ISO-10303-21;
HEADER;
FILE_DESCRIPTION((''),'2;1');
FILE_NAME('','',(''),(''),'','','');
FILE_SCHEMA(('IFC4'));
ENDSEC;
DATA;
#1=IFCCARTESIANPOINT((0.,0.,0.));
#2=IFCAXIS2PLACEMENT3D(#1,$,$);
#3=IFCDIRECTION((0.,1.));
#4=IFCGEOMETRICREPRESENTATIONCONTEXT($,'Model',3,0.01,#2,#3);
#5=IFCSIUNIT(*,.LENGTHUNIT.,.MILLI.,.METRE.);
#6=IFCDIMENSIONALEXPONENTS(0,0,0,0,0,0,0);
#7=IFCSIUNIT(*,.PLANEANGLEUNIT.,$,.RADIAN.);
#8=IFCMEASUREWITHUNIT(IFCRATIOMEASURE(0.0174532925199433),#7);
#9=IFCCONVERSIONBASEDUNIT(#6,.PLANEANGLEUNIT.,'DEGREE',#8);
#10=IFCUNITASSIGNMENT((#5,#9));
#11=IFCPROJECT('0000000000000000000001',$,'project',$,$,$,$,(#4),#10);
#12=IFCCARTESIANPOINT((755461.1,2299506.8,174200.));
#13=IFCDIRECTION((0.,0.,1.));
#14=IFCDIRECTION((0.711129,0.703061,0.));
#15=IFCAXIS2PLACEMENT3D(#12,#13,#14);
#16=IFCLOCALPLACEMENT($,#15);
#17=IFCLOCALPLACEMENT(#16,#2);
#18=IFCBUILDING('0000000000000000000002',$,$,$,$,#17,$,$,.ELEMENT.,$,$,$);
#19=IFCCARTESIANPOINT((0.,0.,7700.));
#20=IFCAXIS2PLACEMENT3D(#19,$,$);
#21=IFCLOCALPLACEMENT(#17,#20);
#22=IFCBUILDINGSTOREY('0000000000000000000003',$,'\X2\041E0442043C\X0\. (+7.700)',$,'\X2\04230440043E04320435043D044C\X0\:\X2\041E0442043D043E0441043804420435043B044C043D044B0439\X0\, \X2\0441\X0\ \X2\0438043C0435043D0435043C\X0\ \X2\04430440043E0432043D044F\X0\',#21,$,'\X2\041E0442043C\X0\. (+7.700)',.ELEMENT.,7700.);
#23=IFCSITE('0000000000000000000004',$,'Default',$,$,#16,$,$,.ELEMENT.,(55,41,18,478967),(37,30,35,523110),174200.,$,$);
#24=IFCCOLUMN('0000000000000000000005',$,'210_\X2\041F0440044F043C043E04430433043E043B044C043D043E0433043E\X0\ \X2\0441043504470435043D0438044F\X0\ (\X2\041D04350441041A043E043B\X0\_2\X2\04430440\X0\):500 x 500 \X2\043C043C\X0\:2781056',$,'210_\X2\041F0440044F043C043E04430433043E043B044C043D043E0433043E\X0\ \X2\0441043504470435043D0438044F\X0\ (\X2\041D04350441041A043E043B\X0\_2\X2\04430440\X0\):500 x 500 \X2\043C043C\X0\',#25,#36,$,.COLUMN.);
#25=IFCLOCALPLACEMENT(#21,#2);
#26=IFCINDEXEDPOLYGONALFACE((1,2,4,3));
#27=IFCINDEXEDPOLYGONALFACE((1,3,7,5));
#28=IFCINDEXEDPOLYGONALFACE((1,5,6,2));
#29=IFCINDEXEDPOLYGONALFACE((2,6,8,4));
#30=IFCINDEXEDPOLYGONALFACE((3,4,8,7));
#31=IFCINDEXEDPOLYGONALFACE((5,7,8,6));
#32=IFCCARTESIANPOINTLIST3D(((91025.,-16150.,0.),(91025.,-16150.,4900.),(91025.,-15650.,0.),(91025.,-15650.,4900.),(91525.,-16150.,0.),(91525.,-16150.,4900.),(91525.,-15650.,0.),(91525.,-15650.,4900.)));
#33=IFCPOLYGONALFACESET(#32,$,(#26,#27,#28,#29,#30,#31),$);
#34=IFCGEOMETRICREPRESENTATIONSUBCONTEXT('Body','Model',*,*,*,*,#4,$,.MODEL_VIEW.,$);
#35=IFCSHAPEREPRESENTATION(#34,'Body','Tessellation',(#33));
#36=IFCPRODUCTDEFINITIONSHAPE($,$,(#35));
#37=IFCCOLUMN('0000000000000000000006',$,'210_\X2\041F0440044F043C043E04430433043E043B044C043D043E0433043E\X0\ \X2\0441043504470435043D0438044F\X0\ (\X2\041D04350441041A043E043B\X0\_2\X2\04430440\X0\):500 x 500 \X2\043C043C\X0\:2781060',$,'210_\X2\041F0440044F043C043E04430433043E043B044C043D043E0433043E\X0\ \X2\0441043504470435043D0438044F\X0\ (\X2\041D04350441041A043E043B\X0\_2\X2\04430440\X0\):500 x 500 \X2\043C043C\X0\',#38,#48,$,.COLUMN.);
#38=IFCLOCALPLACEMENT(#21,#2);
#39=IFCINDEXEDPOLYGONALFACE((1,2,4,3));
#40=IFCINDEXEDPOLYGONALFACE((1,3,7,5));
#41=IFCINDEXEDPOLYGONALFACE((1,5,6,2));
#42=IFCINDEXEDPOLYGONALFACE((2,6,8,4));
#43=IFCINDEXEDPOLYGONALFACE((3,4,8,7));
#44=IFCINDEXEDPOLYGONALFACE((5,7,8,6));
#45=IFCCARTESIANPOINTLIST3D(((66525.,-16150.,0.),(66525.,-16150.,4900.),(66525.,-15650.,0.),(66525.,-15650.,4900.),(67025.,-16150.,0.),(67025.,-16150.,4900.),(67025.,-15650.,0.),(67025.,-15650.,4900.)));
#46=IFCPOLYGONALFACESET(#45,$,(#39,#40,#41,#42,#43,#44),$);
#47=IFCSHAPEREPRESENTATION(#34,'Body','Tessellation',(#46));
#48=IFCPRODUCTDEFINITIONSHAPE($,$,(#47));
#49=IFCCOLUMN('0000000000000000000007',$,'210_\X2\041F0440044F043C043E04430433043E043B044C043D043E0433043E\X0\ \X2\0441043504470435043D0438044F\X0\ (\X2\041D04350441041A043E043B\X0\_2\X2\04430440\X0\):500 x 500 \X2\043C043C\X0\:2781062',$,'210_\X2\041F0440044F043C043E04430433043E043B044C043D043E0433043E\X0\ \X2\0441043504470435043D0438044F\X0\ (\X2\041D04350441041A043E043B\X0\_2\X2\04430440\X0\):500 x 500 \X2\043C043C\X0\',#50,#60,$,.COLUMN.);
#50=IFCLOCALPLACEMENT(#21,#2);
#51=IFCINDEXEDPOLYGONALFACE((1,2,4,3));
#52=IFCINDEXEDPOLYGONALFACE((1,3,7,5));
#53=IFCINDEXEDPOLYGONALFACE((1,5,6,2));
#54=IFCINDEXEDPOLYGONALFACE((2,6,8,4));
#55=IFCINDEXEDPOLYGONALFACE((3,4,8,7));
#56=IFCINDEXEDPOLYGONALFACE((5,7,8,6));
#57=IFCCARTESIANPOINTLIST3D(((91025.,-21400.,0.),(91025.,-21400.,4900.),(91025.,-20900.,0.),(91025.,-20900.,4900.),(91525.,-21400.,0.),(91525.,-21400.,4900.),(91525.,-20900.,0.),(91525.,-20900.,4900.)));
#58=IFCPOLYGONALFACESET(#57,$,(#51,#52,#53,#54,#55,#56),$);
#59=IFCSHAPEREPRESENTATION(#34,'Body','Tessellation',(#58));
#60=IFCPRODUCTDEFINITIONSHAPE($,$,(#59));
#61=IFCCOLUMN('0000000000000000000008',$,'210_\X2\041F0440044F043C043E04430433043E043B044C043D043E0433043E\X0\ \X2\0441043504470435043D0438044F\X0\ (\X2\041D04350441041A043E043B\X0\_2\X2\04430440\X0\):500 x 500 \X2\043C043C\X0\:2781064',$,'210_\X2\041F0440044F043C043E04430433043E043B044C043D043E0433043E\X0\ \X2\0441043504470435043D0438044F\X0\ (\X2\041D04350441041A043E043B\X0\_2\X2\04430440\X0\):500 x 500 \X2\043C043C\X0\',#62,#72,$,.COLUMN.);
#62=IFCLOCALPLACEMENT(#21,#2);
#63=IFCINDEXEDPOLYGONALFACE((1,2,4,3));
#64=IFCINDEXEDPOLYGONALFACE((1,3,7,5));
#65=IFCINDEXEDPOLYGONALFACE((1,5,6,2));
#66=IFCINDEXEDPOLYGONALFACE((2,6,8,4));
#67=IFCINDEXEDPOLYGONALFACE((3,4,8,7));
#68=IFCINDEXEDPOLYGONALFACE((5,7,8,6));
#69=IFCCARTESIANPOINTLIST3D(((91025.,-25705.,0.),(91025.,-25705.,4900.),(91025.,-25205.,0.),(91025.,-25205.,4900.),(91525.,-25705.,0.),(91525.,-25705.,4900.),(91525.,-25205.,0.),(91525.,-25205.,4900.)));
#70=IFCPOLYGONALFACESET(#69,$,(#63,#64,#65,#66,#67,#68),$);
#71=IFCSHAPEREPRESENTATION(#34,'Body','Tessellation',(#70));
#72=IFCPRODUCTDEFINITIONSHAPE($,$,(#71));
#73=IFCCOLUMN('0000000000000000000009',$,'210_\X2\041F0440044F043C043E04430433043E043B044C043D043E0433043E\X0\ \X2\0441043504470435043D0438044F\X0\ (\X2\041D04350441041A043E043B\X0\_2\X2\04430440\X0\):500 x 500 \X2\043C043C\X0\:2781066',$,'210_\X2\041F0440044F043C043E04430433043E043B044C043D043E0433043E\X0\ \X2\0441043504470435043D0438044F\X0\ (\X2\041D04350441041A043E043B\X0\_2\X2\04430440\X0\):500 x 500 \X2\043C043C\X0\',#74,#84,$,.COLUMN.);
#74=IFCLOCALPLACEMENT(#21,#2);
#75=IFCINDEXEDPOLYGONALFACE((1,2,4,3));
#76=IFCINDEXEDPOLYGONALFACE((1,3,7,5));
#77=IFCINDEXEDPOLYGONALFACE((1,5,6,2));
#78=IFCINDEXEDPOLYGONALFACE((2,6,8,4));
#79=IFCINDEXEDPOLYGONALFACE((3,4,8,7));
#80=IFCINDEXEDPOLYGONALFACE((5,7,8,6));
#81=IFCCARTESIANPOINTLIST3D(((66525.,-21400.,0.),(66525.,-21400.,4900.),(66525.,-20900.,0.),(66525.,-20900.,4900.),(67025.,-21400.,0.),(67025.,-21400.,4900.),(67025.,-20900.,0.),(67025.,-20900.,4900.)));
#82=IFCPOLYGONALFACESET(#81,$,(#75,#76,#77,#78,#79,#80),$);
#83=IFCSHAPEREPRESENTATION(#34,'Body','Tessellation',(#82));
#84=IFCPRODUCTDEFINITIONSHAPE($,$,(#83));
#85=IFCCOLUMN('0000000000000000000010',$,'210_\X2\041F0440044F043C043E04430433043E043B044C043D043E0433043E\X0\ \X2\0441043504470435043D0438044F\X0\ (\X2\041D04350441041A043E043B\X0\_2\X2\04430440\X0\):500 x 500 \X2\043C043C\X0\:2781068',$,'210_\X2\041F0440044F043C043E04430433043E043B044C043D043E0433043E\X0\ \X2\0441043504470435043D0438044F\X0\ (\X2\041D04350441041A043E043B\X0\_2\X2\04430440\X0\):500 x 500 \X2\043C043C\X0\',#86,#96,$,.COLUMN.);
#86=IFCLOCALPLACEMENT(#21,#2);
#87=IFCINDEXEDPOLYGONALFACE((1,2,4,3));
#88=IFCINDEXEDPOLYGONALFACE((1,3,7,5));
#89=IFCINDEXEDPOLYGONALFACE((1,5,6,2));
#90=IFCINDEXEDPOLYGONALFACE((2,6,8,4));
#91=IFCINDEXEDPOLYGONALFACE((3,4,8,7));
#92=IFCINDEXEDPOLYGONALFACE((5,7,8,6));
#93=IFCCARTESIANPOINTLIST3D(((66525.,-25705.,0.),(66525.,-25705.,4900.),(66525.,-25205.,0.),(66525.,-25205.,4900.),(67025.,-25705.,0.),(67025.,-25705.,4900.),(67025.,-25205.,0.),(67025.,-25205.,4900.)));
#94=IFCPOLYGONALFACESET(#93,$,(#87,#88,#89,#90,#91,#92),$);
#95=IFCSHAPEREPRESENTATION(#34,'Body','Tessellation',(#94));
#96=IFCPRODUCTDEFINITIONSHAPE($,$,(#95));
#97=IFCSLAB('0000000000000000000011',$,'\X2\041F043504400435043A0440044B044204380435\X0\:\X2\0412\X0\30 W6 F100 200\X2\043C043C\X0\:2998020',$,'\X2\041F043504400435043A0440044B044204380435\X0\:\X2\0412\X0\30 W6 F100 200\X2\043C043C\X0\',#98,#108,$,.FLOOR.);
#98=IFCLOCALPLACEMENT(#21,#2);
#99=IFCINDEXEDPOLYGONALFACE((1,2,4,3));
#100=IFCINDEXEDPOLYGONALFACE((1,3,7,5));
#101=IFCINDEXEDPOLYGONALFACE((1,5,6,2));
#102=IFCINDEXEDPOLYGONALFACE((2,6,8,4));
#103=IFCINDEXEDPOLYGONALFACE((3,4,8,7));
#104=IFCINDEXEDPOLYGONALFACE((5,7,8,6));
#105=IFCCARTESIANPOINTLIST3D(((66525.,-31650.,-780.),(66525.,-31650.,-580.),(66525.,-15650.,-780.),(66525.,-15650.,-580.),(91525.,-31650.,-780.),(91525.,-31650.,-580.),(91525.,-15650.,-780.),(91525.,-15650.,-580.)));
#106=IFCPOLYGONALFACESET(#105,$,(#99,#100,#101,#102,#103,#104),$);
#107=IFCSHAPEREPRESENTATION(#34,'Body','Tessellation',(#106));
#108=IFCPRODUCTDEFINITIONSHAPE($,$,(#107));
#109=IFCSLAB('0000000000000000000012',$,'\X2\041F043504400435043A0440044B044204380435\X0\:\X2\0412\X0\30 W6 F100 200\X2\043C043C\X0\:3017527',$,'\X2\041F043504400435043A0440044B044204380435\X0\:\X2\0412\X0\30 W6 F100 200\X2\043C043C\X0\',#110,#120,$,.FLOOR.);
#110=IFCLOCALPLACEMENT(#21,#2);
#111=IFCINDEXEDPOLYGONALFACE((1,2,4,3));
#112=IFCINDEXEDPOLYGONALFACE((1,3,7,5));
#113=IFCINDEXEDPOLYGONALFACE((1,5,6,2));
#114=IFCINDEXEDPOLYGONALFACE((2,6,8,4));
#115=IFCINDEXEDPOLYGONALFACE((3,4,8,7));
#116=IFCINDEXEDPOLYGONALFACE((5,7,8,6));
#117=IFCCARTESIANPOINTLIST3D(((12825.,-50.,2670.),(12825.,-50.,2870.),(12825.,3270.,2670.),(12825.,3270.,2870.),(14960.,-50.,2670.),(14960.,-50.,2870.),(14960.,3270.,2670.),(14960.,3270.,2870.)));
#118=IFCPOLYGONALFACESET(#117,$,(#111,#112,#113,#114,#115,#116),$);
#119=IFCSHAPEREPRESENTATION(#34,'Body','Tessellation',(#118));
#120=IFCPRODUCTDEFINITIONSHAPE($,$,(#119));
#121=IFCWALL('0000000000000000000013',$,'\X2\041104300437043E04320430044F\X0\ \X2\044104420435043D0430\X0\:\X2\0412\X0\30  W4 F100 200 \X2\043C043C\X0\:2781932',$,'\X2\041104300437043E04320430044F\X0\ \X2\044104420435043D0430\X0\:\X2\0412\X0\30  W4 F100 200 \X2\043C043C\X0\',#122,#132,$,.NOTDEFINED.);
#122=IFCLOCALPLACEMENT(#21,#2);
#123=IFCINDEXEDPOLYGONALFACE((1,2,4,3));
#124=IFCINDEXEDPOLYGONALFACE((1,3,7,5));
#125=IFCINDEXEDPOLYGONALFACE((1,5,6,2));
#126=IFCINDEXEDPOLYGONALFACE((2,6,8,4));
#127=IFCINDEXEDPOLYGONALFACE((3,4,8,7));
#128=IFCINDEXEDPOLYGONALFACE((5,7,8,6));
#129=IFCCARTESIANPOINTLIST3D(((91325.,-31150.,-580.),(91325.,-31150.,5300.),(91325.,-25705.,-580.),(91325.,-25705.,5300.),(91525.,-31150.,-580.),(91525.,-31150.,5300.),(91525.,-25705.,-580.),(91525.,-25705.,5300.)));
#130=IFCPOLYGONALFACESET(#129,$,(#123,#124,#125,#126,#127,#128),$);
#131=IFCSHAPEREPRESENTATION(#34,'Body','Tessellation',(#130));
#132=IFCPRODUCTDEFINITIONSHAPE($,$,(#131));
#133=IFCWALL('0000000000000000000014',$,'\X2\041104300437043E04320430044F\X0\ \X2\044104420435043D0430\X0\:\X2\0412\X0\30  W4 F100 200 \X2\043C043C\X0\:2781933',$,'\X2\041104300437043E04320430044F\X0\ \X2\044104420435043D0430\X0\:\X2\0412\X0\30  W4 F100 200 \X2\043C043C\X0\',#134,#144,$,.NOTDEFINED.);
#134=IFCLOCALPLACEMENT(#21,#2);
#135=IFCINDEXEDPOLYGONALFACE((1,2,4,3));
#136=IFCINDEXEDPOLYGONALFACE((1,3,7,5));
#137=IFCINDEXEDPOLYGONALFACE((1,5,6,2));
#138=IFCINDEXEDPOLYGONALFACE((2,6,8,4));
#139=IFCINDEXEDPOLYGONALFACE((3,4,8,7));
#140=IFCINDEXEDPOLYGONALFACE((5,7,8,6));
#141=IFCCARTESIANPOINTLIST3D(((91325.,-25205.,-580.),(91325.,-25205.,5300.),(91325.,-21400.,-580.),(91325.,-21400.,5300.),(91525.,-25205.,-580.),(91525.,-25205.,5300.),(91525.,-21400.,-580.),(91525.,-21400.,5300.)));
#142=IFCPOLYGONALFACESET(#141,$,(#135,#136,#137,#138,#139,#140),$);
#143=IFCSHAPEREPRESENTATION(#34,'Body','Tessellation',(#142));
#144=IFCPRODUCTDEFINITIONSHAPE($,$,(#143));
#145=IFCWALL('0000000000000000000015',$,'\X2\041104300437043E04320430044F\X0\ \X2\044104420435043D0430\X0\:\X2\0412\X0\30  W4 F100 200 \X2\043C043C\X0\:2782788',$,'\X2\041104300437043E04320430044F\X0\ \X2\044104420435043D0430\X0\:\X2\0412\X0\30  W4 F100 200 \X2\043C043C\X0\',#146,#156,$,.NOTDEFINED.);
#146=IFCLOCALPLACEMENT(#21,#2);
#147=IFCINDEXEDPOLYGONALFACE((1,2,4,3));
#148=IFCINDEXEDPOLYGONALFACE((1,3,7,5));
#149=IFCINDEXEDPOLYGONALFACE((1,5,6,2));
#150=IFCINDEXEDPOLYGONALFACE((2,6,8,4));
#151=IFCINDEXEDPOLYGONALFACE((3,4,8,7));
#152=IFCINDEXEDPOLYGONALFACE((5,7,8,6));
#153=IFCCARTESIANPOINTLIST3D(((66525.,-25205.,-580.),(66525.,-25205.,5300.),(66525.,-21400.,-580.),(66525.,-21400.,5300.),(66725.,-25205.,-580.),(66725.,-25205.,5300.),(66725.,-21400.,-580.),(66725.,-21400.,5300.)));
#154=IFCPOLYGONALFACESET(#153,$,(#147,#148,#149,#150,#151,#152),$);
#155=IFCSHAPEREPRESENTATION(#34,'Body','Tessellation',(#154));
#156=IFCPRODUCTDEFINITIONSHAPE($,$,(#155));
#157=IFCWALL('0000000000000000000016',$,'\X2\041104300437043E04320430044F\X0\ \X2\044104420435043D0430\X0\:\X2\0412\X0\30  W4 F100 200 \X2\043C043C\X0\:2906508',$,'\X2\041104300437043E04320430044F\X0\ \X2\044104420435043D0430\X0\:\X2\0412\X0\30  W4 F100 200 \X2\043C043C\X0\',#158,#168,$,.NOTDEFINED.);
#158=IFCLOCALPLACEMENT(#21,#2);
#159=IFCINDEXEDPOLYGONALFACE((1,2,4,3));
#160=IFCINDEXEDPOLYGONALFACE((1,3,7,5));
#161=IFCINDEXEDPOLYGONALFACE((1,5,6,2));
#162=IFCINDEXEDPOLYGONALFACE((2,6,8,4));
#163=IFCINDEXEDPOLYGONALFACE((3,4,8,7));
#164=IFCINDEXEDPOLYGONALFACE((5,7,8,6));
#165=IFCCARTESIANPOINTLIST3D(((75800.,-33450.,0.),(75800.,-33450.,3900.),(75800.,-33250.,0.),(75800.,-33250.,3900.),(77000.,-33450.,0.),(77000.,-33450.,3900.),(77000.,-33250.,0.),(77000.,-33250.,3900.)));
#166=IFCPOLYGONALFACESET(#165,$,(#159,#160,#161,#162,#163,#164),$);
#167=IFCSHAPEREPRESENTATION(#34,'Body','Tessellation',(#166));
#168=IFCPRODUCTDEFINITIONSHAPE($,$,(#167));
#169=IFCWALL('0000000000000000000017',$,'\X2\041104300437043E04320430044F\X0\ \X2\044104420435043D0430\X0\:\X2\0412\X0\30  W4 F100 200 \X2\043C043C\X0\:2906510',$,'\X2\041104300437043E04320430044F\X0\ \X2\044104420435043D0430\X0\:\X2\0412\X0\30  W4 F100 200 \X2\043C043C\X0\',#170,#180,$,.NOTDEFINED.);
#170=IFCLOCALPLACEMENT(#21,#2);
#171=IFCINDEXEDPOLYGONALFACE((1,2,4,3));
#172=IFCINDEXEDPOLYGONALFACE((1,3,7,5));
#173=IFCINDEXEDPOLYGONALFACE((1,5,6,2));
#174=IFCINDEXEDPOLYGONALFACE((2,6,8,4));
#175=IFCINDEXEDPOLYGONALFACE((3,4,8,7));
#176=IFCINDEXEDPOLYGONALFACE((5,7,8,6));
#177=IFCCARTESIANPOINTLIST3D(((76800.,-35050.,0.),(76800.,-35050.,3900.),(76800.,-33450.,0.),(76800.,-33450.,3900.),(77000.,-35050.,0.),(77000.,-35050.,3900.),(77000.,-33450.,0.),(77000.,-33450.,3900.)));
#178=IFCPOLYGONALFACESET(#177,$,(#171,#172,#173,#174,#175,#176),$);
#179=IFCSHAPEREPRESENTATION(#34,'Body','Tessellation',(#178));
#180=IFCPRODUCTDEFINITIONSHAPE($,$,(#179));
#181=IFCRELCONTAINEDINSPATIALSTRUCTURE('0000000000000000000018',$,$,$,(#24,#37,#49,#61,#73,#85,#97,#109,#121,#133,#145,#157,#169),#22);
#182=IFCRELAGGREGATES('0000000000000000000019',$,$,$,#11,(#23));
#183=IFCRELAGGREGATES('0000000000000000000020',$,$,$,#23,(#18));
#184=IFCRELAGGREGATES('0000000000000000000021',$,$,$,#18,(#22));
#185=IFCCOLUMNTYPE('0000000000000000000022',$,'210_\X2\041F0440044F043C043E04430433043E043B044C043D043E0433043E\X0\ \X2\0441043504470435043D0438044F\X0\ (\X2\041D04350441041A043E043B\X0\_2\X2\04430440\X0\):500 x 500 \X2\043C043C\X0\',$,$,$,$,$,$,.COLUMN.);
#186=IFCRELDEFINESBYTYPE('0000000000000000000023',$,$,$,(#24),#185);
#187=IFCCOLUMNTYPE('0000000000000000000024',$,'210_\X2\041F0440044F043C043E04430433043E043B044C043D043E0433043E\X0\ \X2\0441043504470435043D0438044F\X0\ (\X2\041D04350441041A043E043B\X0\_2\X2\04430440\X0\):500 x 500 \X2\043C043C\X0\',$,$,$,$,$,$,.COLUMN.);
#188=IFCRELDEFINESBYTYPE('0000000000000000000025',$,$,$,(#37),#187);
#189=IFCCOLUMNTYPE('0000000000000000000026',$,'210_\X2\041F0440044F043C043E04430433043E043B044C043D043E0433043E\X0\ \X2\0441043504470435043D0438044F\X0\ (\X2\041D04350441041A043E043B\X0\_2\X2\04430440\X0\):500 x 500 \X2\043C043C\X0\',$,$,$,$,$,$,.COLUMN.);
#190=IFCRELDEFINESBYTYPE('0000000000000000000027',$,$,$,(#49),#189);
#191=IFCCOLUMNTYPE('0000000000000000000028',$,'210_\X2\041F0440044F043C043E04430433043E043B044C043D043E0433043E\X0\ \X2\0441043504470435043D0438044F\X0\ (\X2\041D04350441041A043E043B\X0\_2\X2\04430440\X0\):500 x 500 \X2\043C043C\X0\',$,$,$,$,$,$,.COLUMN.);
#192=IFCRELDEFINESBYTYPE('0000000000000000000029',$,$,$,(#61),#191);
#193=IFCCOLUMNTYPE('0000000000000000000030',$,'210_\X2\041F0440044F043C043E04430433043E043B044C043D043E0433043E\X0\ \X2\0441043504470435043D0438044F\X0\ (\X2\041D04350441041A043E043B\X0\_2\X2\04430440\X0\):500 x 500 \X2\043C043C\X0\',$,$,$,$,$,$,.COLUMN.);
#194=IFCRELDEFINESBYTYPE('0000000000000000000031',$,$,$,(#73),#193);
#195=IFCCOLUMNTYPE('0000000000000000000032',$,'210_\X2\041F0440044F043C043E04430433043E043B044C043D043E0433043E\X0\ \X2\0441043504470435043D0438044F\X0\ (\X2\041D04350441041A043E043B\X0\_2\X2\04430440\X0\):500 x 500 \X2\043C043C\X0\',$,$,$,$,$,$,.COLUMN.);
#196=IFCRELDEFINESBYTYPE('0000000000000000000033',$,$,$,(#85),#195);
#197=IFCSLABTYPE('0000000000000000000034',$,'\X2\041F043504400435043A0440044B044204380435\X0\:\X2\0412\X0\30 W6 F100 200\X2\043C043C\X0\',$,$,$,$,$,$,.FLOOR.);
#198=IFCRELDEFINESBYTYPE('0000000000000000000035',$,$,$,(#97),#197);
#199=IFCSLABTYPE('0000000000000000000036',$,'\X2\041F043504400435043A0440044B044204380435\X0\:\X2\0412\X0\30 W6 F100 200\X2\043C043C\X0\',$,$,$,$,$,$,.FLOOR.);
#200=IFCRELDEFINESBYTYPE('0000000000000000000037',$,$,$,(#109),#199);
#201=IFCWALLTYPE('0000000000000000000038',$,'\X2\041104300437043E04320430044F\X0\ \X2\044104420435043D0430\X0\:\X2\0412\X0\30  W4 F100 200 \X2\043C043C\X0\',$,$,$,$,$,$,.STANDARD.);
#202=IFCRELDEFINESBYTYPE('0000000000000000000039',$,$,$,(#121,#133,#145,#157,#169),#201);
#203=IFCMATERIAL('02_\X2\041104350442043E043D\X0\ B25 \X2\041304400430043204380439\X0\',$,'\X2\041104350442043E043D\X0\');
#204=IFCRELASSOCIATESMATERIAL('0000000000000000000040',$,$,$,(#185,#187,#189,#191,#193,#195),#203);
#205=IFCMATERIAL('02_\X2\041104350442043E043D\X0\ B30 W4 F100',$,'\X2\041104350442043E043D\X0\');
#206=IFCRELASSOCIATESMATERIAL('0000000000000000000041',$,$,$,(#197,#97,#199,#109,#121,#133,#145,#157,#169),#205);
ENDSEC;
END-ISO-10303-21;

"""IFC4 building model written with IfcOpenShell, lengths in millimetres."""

from ifc_helpers import new_model, entity, si_unit, converted_unit, direction, frame, origin, place, context, subcontext, project, spatial, indexed_curve, outline, extrude, source, transform, mapped, material, type_object, type_shapes, element, save


model = new_model("IFC4")

# Units and contexts
model_context = context("Model", 3, precision=0.01, world=origin(), true_north=direction((0.0, 1.0)))
body_context = subcontext(model_context, "Body", "Model", "MODEL_VIEW")
ifc_project = project(units=[si_unit("LENGTHUNIT", "METRE", prefix="MILLI"), converted_unit("PLANEANGLEUNIT", "DEGREE", entity("IfcRatioMeasure", 0.0174532925199433), si_unit("PLANEANGLEUNIT", "RADIAN"), dimensions=[0, 0, 0, 0, 0, 0, 0])], contexts=[model_context])

# Site, building, storey
site_placement = place(None, frame((755461.1, 2299506.8, 174200.0), z_axis=(0.0, 0.0, 1.0), x_axis=(0.711129, 0.703061, 0.0)))
site = spatial("IfcSite", under=ifc_project, at=site_placement, Name="Default", CompositionType="ELEMENT", RefLatitude=(55, 41, 18, 478967), RefLongitude=(37, 30, 35, 523110), RefElevation=174200.0)
building_placement = place(site_placement, origin())
building = spatial("IfcBuilding", under=site, at=building_placement, CompositionType="ELEMENT")
storey_placement = place(building_placement, frame((0.0, 0.0, 7700.0)))
storey = spatial("IfcBuildingStorey", under=building, at=storey_placement, Name="Отм. (+7.700)", ObjectType="Уровень:Относительный, с именем уровня", LongName="Отм. (+7.700)", CompositionType="ELEMENT", Elevation=7700.0)

# Columns
ifc_material_1 = material(Name="02_Бетон B25 Гравий", Category="Бетон")
column_type_1 = type_object("IfcColumnType", Name="210_Прямоугольного сечения (НесКол_2ур):500 x 500 мм", PredefinedType="COLUMN", material=ifc_material_1)
shared_shape_1 = source(origin(), body_context, "Body", "SweptSolid", [
    extrude(outline(indexed_curve([(-250.0, -250.0), (250.0, -250.0), (250.0, 250.0), (-250.0, 250.0), (-250.0, -250.0)], self_intersect=False)), frame((91275.0, -15900.0, 7700.0), z_axis=(0.0, 0.0, 1.0), x_axis=(0.0, -1.0, 0.0)), (0.0, 0.0, 1.0), 4900.0),
])
type_shapes(column_type_1, [shared_shape_1])
column_1_placement = place(storey_placement, frame((0.0, 0.0, -7700.0)))
element("IfcColumn", 1, at=column_1_placement, inside=storey, type_object=column_type_1, Name="210_Прямоугольного сечения (НесКол_2ур):500 x 500 мм:2781056", ObjectType="210_Прямоугольного сечения (НесКол_2ур):500 x 500 мм", PredefinedType="COLUMN", context=body_context, shape_type="MappedRepresentation", body=[
    mapped(shared_shape_1, transform((0.0, 0.0, 0.0), scale=1.0)),
])
column_type_2 = type_object("IfcColumnType", Name="210_Прямоугольного сечения (НесКол_2ур):500 x 500 мм", PredefinedType="COLUMN", material=ifc_material_1)
shared_shape_2 = source(origin(), body_context, "Body", "SweptSolid", [
    extrude(outline(indexed_curve([(-250.0, -250.0), (250.0, -250.0), (250.0, 250.0), (-250.0, 250.0), (-250.0, -250.0)], self_intersect=False)), frame((66775.0, -15900.0, 7700.0), z_axis=(0.0, 0.0, 1.0), x_axis=(0.0, -1.0, 0.0)), (0.0, 0.0, 1.0), 4900.0),
])
type_shapes(column_type_2, [shared_shape_2])
column_2_placement = place(storey_placement, frame((0.0, 0.0, -7700.0)))
element("IfcColumn", 2, at=column_2_placement, inside=storey, type_object=column_type_2, Name="210_Прямоугольного сечения (НесКол_2ур):500 x 500 мм:2781060", ObjectType="210_Прямоугольного сечения (НесКол_2ур):500 x 500 мм", PredefinedType="COLUMN", context=body_context, shape_type="MappedRepresentation", body=[
    mapped(shared_shape_2, transform((0.0, 0.0, 0.0), scale=1.0)),
])
column_type_3 = type_object("IfcColumnType", Name="210_Прямоугольного сечения (НесКол_2ур):500 x 500 мм", PredefinedType="COLUMN", material=ifc_material_1)
shared_shape_3 = source(origin(), body_context, "Body", "SweptSolid", [
    extrude(outline(indexed_curve([(-250.0, -250.0), (250.0, -250.0), (250.0, 250.0), (-250.0, 250.0), (-250.0, -250.0)], self_intersect=False)), frame((91275.0, -21150.0, 7700.0), z_axis=(0.0, 0.0, 1.0), x_axis=(0.0, -1.0, 0.0)), (0.0, 0.0, 1.0), 4900.0),
])
type_shapes(column_type_3, [shared_shape_3])
column_3_placement = place(storey_placement, frame((0.0, 0.0, -7700.0)))
element("IfcColumn", 3, at=column_3_placement, inside=storey, type_object=column_type_3, Name="210_Прямоугольного сечения (НесКол_2ур):500 x 500 мм:2781062", ObjectType="210_Прямоугольного сечения (НесКол_2ур):500 x 500 мм", PredefinedType="COLUMN", context=body_context, shape_type="MappedRepresentation", body=[
    mapped(shared_shape_3, transform((0.0, 0.0, 0.0), scale=1.0)),
])
column_type_4 = type_object("IfcColumnType", Name="210_Прямоугольного сечения (НесКол_2ур):500 x 500 мм", PredefinedType="COLUMN", material=ifc_material_1)
shared_shape_4 = source(origin(), body_context, "Body", "SweptSolid", [
    extrude(outline(indexed_curve([(-250.0, -250.0), (250.0, -250.0), (250.0, 250.0), (-250.0, 250.0), (-250.0, -250.0)], self_intersect=False)), frame((91275.0, -25455.0, 7700.0), z_axis=(0.0, 0.0, 1.0), x_axis=(0.0, -1.0, 0.0)), (0.0, 0.0, 1.0), 4900.0),
])
type_shapes(column_type_4, [shared_shape_4])
column_4_placement = place(storey_placement, frame((0.0, 0.0, -7700.0)))
element("IfcColumn", 4, at=column_4_placement, inside=storey, type_object=column_type_4, Name="210_Прямоугольного сечения (НесКол_2ур):500 x 500 мм:2781064", ObjectType="210_Прямоугольного сечения (НесКол_2ур):500 x 500 мм", PredefinedType="COLUMN", context=body_context, shape_type="MappedRepresentation", body=[
    mapped(shared_shape_4, transform((0.0, 0.0, 0.0), scale=1.0)),
])
column_type_5 = type_object("IfcColumnType", Name="210_Прямоугольного сечения (НесКол_2ур):500 x 500 мм", PredefinedType="COLUMN", material=ifc_material_1)
shared_shape_5 = source(origin(), body_context, "Body", "SweptSolid", [
    extrude(outline(indexed_curve([(-250.0, -250.0), (250.0, -250.0), (250.0, 250.0), (-250.0, 250.0), (-250.0, -250.0)], self_intersect=False)), frame((66775.0, -21150.0, 7700.0), z_axis=(0.0, 0.0, 1.0), x_axis=(0.0, -1.0, 0.0)), (0.0, 0.0, 1.0), 4900.0),
])
type_shapes(column_type_5, [shared_shape_5])
column_5_placement = place(storey_placement, frame((0.0, 0.0, -7700.0)))
element("IfcColumn", 5, at=column_5_placement, inside=storey, type_object=column_type_5, Name="210_Прямоугольного сечения (НесКол_2ур):500 x 500 мм:2781066", ObjectType="210_Прямоугольного сечения (НесКол_2ур):500 x 500 мм", PredefinedType="COLUMN", context=body_context, shape_type="MappedRepresentation", body=[
    mapped(shared_shape_5, transform((0.0, 0.0, 0.0), scale=1.0)),
])
column_type_6 = type_object("IfcColumnType", Name="210_Прямоугольного сечения (НесКол_2ур):500 x 500 мм", PredefinedType="COLUMN", material=ifc_material_1)
shared_shape_6 = source(origin(), body_context, "Body", "SweptSolid", [
    extrude(outline(indexed_curve([(-250.0, -250.0), (250.0, -250.0), (250.0, 250.0), (-250.0, 250.0), (-250.0, -250.0)], self_intersect=False)), frame((66775.0, -25455.0, 7700.0), z_axis=(0.0, 0.0, 1.0), x_axis=(0.0, -1.0, 0.0)), (0.0, 0.0, 1.0), 4900.0),
])
type_shapes(column_type_6, [shared_shape_6])
column_6_placement = place(storey_placement, frame((0.0, 0.0, -7700.0)))
element("IfcColumn", 6, at=column_6_placement, inside=storey, type_object=column_type_6, Name="210_Прямоугольного сечения (НесКол_2ур):500 x 500 мм:2781068", ObjectType="210_Прямоугольного сечения (НесКол_2ур):500 x 500 мм", PredefinedType="COLUMN", context=body_context, shape_type="MappedRepresentation", body=[
    mapped(shared_shape_6, transform((0.0, 0.0, 0.0), scale=1.0)),
])

# Slabs
ifc_material_2 = material(Name="02_Бетон B30 W4 F100", Category="Бетон")
slab_type_1 = type_object("IfcSlabType", Name="Перекрытие:В30 W6 F100 200мм", PredefinedType="FLOOR", material=ifc_material_2)
slab_1_placement = place(storey_placement, origin())
element("IfcSlab", 7, at=slab_1_placement, inside=storey, type_object=slab_type_1, material=ifc_material_2, Name="Перекрытие:В30 W6 F100 200мм:2998020", ObjectType="Перекрытие:В30 W6 F100 200мм", PredefinedType="FLOOR", context=body_context, shape_type="SweptSolid", body=[
    extrude(outline(indexed_curve([(-8000.0, -12500.0), (8000.0, -12500.0), (8000.0, 12500.0), (-8000.0, 12500.0), (-8000.0, -12500.0)], self_intersect=False)), frame((79025.0, -23650.0, -580.0), z_axis=(0.0, 0.0, -1.0), x_axis=(0.0, 1.0, 0.0)), (0.0, 0.0, 1.0), 200.0),
])
slab_type_2 = type_object("IfcSlabType", Name="Перекрытие:В30 W6 F100 200мм", PredefinedType="FLOOR", material=ifc_material_2)
slab_2_placement = place(storey_placement, origin())
element("IfcSlab", 8, at=slab_2_placement, inside=storey, type_object=slab_type_2, material=ifc_material_2, Name="Перекрытие:В30 W6 F100 200мм:3017527", ObjectType="Перекрытие:В30 W6 F100 200мм", PredefinedType="FLOOR", context=body_context, shape_type="SweptSolid", body=[
    extrude(outline(indexed_curve([(-1660.0, -1067.5), (1660.0, -1067.5), (1660.0, 1067.5), (-1660.0, 1067.5), (-1660.0, -1067.5)], self_intersect=False)), frame((13892.5, 1610.0, 2870.0), z_axis=(0.0, 0.0, -1.0), x_axis=(0.0, 1.0, 0.0)), (0.0, 0.0, 1.0), 200.0),
])

# Walls
wall_type = type_object("IfcWallType", Name="Базовая стена:В30  W4 F100 200 мм", PredefinedType="STANDARD")
wall_1_placement = place(storey_placement, frame((91425.0, -25705.0, -580.0), z_axis=(0.0, 0.0, 1.0), x_axis=(0.0, -1.0, 0.0)))
element("IfcWall", 9, at=wall_1_placement, inside=storey, type_object=wall_type, material=ifc_material_2, Name="Базовая стена:В30  W4 F100 200 мм:2781932", ObjectType="Базовая стена:В30  W4 F100 200 мм", PredefinedType="NOTDEFINED", context=body_context, shape_type="SweptSolid", body=[
    extrude(outline(indexed_curve([(5445.0, 100.0), (0.0, 100.0), (0.0, -100.0), (5445.0, -100.0), (5445.0, 100.0)], self_intersect=False)), origin(), (0.0, 0.0, 1.0), 5880.0),
])
wall_2_placement = place(storey_placement, frame((91425.0, -21400.0, -580.0), z_axis=(0.0, 0.0, 1.0), x_axis=(0.0, -1.0, 0.0)))
element("IfcWall", 10, at=wall_2_placement, inside=storey, type_object=wall_type, material=ifc_material_2, Name="Базовая стена:В30  W4 F100 200 мм:2781933", ObjectType="Базовая стена:В30  W4 F100 200 мм", PredefinedType="NOTDEFINED", context=body_context, shape_type="SweptSolid", body=[
    extrude(outline(indexed_curve([(3805.0, 100.0), (0.0, 100.0), (0.0, -100.0), (3805.0, -100.0), (3805.0, 100.0)], self_intersect=False)), origin(), (0.0, 0.0, 1.0), 5880.0),
])
wall_3_placement = place(storey_placement, frame((66625.0, -25205.0, -580.0), z_axis=(0.0, 0.0, 1.0), x_axis=(0.0, 1.0, 0.0)))
element("IfcWall", 11, at=wall_3_placement, inside=storey, type_object=wall_type, material=ifc_material_2, Name="Базовая стена:В30  W4 F100 200 мм:2782788", ObjectType="Базовая стена:В30  W4 F100 200 мм", PredefinedType="NOTDEFINED", context=body_context, shape_type="SweptSolid", body=[
    extrude(outline(indexed_curve([(3805.0, 100.0), (0.0, 100.0), (0.0, -100.0), (3805.0, -100.0), (3805.0, 100.0)], self_intersect=False)), origin(), (0.0, 0.0, 1.0), 5880.0),
])
wall_4_placement = place(storey_placement, frame((75800.0, -33350.0, 0.0)))
element("IfcWall", 12, at=wall_4_placement, inside=storey, type_object=wall_type, material=ifc_material_2, Name="Базовая стена:В30  W4 F100 200 мм:2906508", ObjectType="Базовая стена:В30  W4 F100 200 мм", PredefinedType="NOTDEFINED", context=body_context, shape_type="SweptSolid", body=[
    extrude(outline(indexed_curve([(1200.0, 100.0), (0.0, 100.0), (0.0, -100.0), (1200.0, -100.0), (1200.0, 100.0)], self_intersect=False)), origin(), (0.0, 0.0, 1.0), 3900.0),
])
wall_5_placement = place(storey_placement, frame((76900.0, -33450.0, 0.0), z_axis=(0.0, 0.0, 1.0), x_axis=(0.0, -1.0, 0.0)))
element("IfcWall", 13, at=wall_5_placement, inside=storey, type_object=wall_type, material=ifc_material_2, Name="Базовая стена:В30  W4 F100 200 мм:2906510", ObjectType="Базовая стена:В30  W4 F100 200 мм", PredefinedType="NOTDEFINED", context=body_context, shape_type="SweptSolid", body=[
    extrude(outline(indexed_curve([(1600.0, 100.0), (0.0, 100.0), (0.0, -100.0), (1600.0, -100.0), (1600.0, 100.0)], self_intersect=False)), origin(), (0.0, 0.0, 1.0), 3900.0),
])

save(model, "model.ifc")
